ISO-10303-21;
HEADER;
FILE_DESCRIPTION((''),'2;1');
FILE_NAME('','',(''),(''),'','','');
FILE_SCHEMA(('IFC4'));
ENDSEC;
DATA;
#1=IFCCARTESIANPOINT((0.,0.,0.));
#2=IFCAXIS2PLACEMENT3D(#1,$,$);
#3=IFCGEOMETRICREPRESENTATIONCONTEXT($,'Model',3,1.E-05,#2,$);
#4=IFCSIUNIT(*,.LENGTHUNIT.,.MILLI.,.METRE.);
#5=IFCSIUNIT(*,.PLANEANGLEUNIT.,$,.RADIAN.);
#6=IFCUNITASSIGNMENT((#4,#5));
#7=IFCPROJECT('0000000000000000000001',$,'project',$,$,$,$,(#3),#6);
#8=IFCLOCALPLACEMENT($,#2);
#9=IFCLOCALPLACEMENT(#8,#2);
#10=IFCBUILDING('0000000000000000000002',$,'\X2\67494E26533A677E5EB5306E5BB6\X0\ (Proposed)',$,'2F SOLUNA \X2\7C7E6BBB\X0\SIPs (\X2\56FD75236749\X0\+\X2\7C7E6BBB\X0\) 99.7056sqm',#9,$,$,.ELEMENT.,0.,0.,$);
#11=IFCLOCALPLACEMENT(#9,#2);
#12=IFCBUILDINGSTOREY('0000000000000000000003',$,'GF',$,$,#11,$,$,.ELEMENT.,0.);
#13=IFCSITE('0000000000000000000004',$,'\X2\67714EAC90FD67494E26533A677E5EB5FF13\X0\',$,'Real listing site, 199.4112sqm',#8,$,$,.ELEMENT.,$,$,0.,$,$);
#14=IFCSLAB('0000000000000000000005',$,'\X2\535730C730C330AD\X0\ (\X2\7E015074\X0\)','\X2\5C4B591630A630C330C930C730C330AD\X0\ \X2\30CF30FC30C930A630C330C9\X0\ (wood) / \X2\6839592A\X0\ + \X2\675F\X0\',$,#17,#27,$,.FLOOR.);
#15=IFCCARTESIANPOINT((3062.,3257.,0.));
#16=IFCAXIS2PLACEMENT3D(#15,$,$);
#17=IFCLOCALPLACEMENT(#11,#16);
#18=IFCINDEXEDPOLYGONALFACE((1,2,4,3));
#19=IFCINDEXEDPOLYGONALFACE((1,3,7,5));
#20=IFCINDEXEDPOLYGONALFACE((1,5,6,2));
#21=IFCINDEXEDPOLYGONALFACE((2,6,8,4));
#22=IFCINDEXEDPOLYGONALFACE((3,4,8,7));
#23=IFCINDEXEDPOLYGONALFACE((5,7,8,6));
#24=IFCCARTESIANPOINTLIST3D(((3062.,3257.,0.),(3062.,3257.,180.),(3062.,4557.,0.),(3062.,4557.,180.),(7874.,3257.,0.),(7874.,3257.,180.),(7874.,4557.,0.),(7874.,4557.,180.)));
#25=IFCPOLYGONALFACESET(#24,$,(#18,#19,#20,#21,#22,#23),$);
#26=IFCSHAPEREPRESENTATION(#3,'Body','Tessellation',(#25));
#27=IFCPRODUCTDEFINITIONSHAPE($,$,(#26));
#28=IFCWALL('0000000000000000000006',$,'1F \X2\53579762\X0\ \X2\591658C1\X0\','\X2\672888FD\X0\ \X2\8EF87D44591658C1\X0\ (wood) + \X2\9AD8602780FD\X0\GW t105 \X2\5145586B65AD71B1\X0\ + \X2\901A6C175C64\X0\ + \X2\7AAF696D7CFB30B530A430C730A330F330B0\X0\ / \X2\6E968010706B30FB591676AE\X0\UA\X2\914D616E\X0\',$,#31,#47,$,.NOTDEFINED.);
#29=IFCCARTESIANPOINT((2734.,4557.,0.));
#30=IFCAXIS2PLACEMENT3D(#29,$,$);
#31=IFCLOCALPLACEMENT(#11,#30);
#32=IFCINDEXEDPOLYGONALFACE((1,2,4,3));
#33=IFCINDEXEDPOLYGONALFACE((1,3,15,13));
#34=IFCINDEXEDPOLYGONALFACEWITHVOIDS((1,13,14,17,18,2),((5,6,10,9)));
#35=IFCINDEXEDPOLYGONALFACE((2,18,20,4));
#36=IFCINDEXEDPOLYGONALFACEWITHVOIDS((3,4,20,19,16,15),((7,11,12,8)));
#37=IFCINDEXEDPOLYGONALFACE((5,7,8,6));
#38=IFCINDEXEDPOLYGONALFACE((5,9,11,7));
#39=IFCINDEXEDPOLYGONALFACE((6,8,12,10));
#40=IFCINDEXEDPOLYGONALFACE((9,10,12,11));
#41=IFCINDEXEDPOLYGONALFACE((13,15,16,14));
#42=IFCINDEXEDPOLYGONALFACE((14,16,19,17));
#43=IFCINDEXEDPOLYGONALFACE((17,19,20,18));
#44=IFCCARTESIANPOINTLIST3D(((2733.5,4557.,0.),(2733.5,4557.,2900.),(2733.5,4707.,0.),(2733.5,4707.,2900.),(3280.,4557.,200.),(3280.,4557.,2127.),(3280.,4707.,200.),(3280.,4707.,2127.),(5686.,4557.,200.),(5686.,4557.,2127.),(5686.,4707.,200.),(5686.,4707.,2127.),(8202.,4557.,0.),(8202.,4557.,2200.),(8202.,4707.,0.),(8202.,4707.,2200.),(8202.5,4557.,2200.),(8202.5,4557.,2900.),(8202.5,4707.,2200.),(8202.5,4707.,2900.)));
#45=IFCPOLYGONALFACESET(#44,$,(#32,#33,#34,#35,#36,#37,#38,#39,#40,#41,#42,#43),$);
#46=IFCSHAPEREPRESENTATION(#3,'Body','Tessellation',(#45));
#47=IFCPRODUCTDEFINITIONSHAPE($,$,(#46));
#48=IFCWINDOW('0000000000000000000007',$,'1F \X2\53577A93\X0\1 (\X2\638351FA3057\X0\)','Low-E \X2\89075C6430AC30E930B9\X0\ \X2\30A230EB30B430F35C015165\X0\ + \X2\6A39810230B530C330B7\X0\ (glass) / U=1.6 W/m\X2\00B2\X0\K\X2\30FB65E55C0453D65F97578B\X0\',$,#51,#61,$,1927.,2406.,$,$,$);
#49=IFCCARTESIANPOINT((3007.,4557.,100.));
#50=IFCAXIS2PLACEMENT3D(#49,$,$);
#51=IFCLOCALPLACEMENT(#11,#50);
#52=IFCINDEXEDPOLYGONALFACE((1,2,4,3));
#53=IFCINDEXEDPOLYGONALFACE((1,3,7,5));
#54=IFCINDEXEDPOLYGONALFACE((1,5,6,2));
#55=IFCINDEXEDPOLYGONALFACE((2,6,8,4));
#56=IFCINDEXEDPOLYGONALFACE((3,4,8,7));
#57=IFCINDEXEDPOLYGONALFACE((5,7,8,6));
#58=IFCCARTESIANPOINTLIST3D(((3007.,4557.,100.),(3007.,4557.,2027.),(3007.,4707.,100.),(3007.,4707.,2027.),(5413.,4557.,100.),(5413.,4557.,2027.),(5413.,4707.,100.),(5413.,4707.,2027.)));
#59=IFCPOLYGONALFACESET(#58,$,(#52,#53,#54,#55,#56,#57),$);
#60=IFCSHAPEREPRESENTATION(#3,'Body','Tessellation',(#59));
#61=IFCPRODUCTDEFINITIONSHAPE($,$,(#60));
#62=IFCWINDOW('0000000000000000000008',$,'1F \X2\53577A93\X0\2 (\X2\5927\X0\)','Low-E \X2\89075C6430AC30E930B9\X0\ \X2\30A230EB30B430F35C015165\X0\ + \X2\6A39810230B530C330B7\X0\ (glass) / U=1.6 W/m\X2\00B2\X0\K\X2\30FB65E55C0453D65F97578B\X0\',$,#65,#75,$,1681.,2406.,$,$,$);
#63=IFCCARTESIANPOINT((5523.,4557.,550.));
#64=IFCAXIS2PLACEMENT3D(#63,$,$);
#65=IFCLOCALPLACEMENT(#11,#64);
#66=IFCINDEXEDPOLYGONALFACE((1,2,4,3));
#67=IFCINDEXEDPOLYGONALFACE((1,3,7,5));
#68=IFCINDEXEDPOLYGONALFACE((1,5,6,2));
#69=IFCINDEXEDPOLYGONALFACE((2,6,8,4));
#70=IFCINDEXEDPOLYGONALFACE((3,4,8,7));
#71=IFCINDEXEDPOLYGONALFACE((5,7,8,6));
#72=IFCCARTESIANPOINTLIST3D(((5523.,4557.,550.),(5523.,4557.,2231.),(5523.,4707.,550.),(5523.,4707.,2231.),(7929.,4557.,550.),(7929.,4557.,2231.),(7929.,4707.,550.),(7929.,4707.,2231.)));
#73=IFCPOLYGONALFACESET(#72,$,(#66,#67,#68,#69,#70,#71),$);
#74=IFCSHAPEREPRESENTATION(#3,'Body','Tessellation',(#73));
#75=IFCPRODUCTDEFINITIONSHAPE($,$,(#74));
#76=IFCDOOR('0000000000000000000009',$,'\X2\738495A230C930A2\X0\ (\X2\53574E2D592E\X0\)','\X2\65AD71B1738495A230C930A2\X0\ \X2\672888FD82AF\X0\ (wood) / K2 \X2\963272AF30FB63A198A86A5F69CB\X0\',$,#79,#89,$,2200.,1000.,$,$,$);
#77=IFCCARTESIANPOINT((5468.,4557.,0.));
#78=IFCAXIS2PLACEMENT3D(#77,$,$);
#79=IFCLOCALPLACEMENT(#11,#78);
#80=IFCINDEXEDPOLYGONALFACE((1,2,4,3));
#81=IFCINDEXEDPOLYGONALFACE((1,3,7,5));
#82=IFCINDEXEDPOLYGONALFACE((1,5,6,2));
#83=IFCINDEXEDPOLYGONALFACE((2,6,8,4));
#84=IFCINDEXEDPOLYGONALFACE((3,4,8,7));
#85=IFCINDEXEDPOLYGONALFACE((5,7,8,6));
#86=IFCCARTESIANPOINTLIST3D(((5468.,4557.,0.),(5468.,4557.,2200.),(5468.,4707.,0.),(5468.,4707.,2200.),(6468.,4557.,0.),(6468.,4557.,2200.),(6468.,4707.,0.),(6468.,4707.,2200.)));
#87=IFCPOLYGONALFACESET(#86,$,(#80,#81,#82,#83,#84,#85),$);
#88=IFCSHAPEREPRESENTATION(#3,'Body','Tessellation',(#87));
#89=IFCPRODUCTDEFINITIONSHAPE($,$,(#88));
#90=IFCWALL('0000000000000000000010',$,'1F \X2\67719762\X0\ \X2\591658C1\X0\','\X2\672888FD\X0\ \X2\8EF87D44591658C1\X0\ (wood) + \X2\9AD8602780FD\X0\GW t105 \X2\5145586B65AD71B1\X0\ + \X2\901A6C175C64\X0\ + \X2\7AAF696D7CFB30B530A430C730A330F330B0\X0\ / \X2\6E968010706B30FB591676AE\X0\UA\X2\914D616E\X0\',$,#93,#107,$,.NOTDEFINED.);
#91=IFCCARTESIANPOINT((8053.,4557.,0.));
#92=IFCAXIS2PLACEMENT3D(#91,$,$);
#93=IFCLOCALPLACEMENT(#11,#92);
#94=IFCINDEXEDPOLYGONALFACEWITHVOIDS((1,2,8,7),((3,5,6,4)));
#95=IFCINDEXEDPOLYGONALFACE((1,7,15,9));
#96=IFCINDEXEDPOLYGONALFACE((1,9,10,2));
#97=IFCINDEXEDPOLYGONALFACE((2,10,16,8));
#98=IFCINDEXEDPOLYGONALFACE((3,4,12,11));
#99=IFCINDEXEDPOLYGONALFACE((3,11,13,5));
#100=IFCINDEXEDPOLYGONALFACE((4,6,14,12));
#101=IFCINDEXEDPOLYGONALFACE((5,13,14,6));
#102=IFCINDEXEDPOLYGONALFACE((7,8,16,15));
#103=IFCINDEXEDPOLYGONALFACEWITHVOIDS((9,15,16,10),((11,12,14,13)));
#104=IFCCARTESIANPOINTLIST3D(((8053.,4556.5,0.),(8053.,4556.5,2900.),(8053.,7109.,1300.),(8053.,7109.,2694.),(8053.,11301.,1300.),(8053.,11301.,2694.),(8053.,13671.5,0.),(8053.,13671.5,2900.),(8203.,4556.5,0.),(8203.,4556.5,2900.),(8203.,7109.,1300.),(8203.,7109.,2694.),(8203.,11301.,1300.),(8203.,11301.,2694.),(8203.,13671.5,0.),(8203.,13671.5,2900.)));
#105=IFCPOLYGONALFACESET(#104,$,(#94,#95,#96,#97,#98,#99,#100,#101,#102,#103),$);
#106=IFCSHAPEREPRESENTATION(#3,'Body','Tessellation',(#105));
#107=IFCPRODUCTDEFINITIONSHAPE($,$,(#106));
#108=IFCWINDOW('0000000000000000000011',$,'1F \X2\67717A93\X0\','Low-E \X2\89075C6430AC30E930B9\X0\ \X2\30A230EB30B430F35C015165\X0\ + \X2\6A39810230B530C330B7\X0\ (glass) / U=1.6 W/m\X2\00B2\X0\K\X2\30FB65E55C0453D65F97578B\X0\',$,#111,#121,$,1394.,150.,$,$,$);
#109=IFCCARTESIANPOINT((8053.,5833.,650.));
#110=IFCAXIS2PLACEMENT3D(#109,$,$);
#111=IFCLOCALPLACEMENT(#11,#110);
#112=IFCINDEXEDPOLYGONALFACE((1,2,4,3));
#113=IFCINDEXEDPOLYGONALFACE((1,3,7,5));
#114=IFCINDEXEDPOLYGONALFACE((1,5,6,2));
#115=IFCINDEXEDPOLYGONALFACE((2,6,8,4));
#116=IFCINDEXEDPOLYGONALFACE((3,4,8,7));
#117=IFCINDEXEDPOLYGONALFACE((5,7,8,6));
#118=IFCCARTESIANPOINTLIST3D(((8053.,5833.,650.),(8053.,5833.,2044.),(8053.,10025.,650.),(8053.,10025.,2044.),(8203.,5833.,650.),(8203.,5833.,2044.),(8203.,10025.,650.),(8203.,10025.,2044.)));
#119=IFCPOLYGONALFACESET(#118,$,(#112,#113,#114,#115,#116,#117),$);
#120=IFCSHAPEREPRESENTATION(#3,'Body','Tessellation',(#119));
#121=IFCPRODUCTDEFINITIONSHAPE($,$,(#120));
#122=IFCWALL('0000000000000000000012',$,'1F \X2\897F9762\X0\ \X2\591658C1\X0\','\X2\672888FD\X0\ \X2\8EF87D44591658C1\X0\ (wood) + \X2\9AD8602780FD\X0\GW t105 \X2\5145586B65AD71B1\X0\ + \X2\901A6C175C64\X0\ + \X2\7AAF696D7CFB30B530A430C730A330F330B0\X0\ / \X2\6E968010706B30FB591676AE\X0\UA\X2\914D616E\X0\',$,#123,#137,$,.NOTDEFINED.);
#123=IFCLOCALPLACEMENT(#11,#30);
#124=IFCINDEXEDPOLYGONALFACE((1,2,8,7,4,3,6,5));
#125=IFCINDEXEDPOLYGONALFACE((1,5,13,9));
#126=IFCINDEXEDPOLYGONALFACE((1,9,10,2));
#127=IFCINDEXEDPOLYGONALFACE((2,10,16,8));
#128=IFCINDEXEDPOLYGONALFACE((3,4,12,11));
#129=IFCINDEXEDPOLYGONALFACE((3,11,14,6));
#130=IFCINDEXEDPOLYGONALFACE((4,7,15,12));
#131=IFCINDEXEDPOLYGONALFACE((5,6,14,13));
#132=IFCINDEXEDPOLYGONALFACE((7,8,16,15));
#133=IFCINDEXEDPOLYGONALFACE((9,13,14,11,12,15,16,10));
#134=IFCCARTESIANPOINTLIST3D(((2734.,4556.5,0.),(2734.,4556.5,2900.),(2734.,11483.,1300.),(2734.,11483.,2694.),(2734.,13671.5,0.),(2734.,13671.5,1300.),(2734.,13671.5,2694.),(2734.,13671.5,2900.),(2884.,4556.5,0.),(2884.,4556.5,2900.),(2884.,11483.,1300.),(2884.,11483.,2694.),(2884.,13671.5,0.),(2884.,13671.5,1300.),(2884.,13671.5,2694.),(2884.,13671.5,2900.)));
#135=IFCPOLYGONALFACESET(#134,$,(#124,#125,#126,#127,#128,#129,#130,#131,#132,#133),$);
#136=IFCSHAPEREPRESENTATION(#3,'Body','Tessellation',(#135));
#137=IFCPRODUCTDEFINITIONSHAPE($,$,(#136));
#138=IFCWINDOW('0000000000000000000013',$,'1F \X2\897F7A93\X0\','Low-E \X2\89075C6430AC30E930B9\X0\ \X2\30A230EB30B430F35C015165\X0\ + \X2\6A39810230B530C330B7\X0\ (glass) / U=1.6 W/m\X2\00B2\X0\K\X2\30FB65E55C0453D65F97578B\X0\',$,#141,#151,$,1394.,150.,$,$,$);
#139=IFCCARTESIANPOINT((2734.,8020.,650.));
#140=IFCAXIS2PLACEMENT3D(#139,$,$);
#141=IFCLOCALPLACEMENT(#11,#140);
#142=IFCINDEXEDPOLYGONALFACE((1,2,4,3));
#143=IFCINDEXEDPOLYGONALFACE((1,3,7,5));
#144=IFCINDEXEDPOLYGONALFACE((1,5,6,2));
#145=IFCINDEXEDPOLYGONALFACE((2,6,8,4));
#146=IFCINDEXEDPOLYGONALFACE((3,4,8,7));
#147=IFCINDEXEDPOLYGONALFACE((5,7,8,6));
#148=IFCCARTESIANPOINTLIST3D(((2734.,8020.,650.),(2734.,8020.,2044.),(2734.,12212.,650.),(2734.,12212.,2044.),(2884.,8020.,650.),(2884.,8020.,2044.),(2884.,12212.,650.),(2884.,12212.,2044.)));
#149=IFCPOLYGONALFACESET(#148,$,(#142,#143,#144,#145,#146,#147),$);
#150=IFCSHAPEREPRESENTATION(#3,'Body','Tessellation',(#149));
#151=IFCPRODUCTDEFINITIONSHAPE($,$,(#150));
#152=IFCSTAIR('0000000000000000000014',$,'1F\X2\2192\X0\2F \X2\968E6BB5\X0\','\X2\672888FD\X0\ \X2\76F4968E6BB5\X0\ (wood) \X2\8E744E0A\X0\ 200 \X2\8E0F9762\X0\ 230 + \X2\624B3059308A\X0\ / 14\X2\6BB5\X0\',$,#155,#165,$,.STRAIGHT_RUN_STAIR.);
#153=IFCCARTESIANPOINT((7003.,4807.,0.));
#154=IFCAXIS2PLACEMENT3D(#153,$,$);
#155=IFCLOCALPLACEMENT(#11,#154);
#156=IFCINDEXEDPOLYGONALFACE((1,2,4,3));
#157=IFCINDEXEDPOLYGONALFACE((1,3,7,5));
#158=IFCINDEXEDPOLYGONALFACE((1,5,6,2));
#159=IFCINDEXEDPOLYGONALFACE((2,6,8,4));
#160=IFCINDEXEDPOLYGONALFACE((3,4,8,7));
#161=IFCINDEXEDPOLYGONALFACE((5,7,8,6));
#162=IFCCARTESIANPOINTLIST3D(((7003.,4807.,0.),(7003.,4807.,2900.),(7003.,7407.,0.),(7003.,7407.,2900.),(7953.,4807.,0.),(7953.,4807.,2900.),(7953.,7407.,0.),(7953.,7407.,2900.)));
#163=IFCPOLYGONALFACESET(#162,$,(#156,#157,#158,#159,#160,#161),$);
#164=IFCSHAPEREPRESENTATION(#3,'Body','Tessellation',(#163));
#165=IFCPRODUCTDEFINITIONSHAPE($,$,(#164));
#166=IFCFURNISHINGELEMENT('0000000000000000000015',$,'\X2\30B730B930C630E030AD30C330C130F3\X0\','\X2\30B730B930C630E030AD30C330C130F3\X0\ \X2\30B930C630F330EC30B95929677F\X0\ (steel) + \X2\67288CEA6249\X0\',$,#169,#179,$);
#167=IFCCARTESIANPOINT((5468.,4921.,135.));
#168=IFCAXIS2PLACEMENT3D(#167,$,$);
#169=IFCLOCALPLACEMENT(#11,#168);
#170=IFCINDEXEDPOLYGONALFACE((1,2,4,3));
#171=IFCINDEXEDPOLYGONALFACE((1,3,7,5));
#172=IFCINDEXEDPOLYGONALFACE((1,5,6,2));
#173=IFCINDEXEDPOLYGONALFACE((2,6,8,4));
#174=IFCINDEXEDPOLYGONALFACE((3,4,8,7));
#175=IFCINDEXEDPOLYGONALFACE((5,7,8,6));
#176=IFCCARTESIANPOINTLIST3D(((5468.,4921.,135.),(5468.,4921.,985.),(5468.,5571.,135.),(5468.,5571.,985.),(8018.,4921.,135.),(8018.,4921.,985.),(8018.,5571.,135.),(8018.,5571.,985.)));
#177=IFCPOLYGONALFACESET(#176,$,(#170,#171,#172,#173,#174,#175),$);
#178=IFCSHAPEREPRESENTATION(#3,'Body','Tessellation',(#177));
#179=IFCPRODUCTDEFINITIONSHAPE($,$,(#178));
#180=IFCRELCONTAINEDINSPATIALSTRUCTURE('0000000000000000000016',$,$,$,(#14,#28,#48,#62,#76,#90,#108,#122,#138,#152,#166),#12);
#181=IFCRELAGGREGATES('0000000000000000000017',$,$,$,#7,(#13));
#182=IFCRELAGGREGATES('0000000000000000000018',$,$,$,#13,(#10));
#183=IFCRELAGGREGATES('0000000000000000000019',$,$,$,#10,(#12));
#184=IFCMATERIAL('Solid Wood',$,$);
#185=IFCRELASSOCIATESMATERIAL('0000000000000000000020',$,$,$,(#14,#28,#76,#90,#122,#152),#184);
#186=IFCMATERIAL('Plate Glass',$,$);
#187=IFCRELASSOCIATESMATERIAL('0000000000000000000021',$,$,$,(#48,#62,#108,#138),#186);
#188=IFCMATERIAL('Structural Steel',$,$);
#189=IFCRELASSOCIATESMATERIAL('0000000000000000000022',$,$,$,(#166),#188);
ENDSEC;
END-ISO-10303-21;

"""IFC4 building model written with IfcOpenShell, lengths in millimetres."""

from ifc_helpers import new_model, si_unit, frame, frame_2d, origin, place, context, project, spatial, rectangle, extrude, material, element, fill, save


model = new_model("IFC4")

# Units and contexts
model_context = context("Model", 3, precision=1e-05, world=origin())
ifc_project = project(units=[si_unit("LENGTHUNIT", "METRE", prefix="MILLI"), si_unit("PLANEANGLEUNIT", "RADIAN")], contexts=[model_context])

# Site, building, storey
site_placement = place(None, origin())
site = spatial("IfcSite", under=ifc_project, at=site_placement, Name="東京都杉並区松庵３", ObjectType="Real listing site, 199.4112sqm", CompositionType="ELEMENT", RefElevation=0.0)
building_placement = place(site_placement, origin())
building = spatial("IfcBuilding", under=site, at=building_placement, Name="杉並区松庵の家 (Proposed)", ObjectType="2F SOLUNA 籾殻SIPs (国産杉+籾殻) 99.7056sqm", CompositionType="ELEMENT", ElevationOfRefHeight=0.0, ElevationOfTerrain=0.0)
storey_placement = place(building_placement, origin())
storey = spatial("IfcBuildingStorey", under=building, at=storey_placement, Name="GF", CompositionType="ELEMENT", Elevation=0.0)

# Slab
ifc_material_1 = material(Name="Solid Wood")
slab_1_placement = place(storey_placement, frame((3062.0, 3257.0, 0.0)))
element("IfcSlab", 1, at=slab_1_placement, inside=storey, material=ifc_material_1, Name="南デッキ (縁側)", Description="屋外ウッドデッキ ハードウッド (wood) / 根太 + 束", PredefinedType="FLOOR", context=model_context, shape_type="SweptSolid", body=[
    extrude(rectangle(XDim=4812.0, YDim=1300.0, at=frame_2d((2406.0, 650.0))), frame((3062.0, 3257.0, 0.0)), (0.0, 0.0, 1.0), 180.0),
])

# Wall, openings, windows, door
wall_1_placement = place(storey_placement, frame((2734.0, 4557.0, 0.0)))
wall_1 = element("IfcWall", 2, at=wall_1_placement, inside=storey, material=ifc_material_1, Name="1F 南面 外壁", Description="木製 軸組外壁 (wood) + 高性能GW t105 充填断熱 + 通気層 + 窯業系サイディング / 準耐火・外皮UA配慮", PredefinedType="NOTDEFINED", context=model_context, shape_type="SweptSolid", body=[
    extrude(rectangle(XDim=5469.0, YDim=150.0, at=frame_2d((2734.0, 75.0))), frame((2734.0, 4557.0, 0.0)), (0.0, 0.0, 1.0), 2900.0),
])
opening_1_placement = place(storey_placement, frame((3007.0, 4557.0, 100.0)))
opening_1 = element("IfcOpeningElement", 3, at=opening_1_placement, cuts=wall_1, PredefinedType="NOTDEFINED", context=model_context, shape_type="SweptSolid", body=[
    extrude(rectangle(XDim=2406.0, YDim=150.0, at=frame_2d((1203.0, 75.0))), frame((3007.0, 4557.0, 100.0)), (0.0, 0.0, 1.0), 1927.0),
])
opening_2_placement = place(storey_placement, frame((5523.0, 4557.0, 550.0)))
opening_2 = element("IfcOpeningElement", 4, at=opening_2_placement, cuts=wall_1, PredefinedType="NOTDEFINED", context=model_context, shape_type="SweptSolid", body=[
    extrude(rectangle(XDim=2406.0, YDim=150.0, at=frame_2d((1203.0, 75.0))), frame((5523.0, 4557.0, 550.0)), (0.0, 0.0, 1.0), 1681.0),
])
opening_3_placement = place(storey_placement, frame((5468.0, 4557.0, 0.0)))
opening_3 = element("IfcOpeningElement", 5, at=opening_3_placement, cuts=wall_1, PredefinedType="NOTDEFINED", context=model_context, shape_type="SweptSolid", body=[
    extrude(rectangle(XDim=1000.0, YDim=150.0, at=frame_2d((500.0, 75.0))), frame((5468.0, 4557.0, 0.0)), (0.0, 0.0, 1.0), 2200.0),
])
ifc_material_2 = material(Name="Plate Glass")
window_1_placement = place(storey_placement, frame((3007.0, 4557.0, 100.0)))
window_1 = element("IfcWindow", 6, at=window_1_placement, inside=storey, material=ifc_material_2, Name="1F 南窓1 (掃出し)", Description="Low-E 複層ガラス アルゴン封入 + 樹脂サッシ (glass) / U=1.6 W/m²K・日射取得型", OverallHeight=1927.0, OverallWidth=2406.0, context=model_context, shape_type="SweptSolid", body=[
    extrude(rectangle(XDim=2406.0, YDim=150.0, at=frame_2d((1203.0, 75.0))), frame((3007.0, 4557.0, 100.0)), (0.0, 0.0, 1.0), 1927.0),
])
fill(opening_1, window_1)
window_2_placement = place(storey_placement, frame((5523.0, 4557.0, 550.0)))
window_2 = element("IfcWindow", 7, at=window_2_placement, inside=storey, material=ifc_material_2, Name="1F 南窓2 (大)", Description="Low-E 複層ガラス アルゴン封入 + 樹脂サッシ (glass) / U=1.6 W/m²K・日射取得型", OverallHeight=1681.0, OverallWidth=2406.0, context=model_context, shape_type="SweptSolid", body=[
    extrude(rectangle(XDim=2406.0, YDim=150.0, at=frame_2d((1203.0, 75.0))), frame((5523.0, 4557.0, 550.0)), (0.0, 0.0, 1.0), 1681.0),
])
fill(opening_2, window_2)
door_placement = place(storey_placement, frame((5468.0, 4557.0, 0.0)))
door = element("IfcDoor", 8, at=door_placement, inside=storey, material=ifc_material_1, Name="玄関ドア (南中央)", Description="断熱玄関ドア 木製芯 (wood) / K2 防犯・採風機構", OverallHeight=2200.0, OverallWidth=1000.0, context=model_context, shape_type="SweptSolid", body=[
    extrude(rectangle(XDim=1000.0, YDim=150.0, at=frame_2d((500.0, 75.0))), frame((5468.0, 4557.0, 0.0)), (0.0, 0.0, 1.0), 2200.0),
])
fill(opening_3, door)

# Walls, openings, windows
wall_2_placement = place(storey_placement, frame((8053.0, 4557.0, 0.0)))
wall_2 = element("IfcWall", 9, at=wall_2_placement, inside=storey, material=ifc_material_1, Name="1F 東面 外壁", Description="木製 軸組外壁 (wood) + 高性能GW t105 充填断熱 + 通気層 + 窯業系サイディング / 準耐火・外皮UA配慮", PredefinedType="NOTDEFINED", context=model_context, shape_type="SweptSolid", body=[
    extrude(rectangle(XDim=150.0, YDim=9115.0, at=frame_2d((75.0, 4557.0))), frame((8053.0, 4557.0, 0.0)), (0.0, 0.0, 1.0), 2900.0),
])
opening_4_placement = place(storey_placement, frame((8053.0, 5833.0, 650.0)))
opening_4 = element("IfcOpeningElement", 10, at=opening_4_placement, cuts=wall_2, PredefinedType="NOTDEFINED", context=model_context, shape_type="SweptSolid", body=[
    extrude(rectangle(XDim=150.0, YDim=4192.0, at=frame_2d((75.0, 2096.0))), frame((8053.0, 5833.0, 650.0)), (0.0, 0.0, 1.0), 1394.0),
])
window_3_placement = place(storey_placement, frame((8053.0, 5833.0, 650.0)))
window_3 = element("IfcWindow", 11, at=window_3_placement, inside=storey, material=ifc_material_2, Name="1F 東窓", Description="Low-E 複層ガラス アルゴン封入 + 樹脂サッシ (glass) / U=1.6 W/m²K・日射取得型", OverallHeight=1394.0, OverallWidth=150.0, context=model_context, shape_type="SweptSolid", body=[
    extrude(rectangle(XDim=150.0, YDim=4192.0, at=frame_2d((75.0, 2096.0))), frame((8053.0, 5833.0, 650.0)), (0.0, 0.0, 1.0), 1394.0),
])
fill(opening_4, window_3)
wall_3_placement = place(storey_placement, frame((2734.0, 4557.0, 0.0)))
wall_3 = element("IfcWall", 12, at=wall_3_placement, inside=storey, material=ifc_material_1, Name="1F 西面 外壁", Description="木製 軸組外壁 (wood) + 高性能GW t105 充填断熱 + 通気層 + 窯業系サイディング / 準耐火・外皮UA配慮", PredefinedType="NOTDEFINED", context=model_context, shape_type="SweptSolid", body=[
    extrude(rectangle(XDim=150.0, YDim=9115.0, at=frame_2d((75.0, 4557.0))), frame((2734.0, 4557.0, 0.0)), (0.0, 0.0, 1.0), 2900.0),
])
opening_5_placement = place(storey_placement, frame((2734.0, 8020.0, 650.0)))
opening_5 = element("IfcOpeningElement", 13, at=opening_5_placement, cuts=wall_3, PredefinedType="NOTDEFINED", context=model_context, shape_type="SweptSolid", body=[
    extrude(rectangle(XDim=150.0, YDim=4192.0, at=frame_2d((75.0, 2096.0))), frame((2734.0, 8020.0, 650.0)), (0.0, 0.0, 1.0), 1394.0),
])
window_4_placement = place(storey_placement, frame((2734.0, 8020.0, 650.0)))
window_4 = element("IfcWindow", 14, at=window_4_placement, inside=storey, material=ifc_material_2, Name="1F 西窓", Description="Low-E 複層ガラス アルゴン封入 + 樹脂サッシ (glass) / U=1.6 W/m²K・日射取得型", OverallHeight=1394.0, OverallWidth=150.0, context=model_context, shape_type="SweptSolid", body=[
    extrude(rectangle(XDim=150.0, YDim=4192.0, at=frame_2d((75.0, 2096.0))), frame((2734.0, 8020.0, 650.0)), (0.0, 0.0, 1.0), 1394.0),
])
fill(opening_5, window_4)

# Stair
stair_placement = place(storey_placement, frame((7003.0, 4807.0, 0.0)))
element("IfcStair", 15, at=stair_placement, inside=storey, material=ifc_material_1, Name="1F→2F 階段", Description="木製 直階段 (wood) 蹴上 200 踏面 230 + 手すり / 14段", PredefinedType="STRAIGHT_RUN_STAIR", context=model_context, shape_type="SweptSolid", body=[
    extrude(rectangle(XDim=950.0, YDim=2600.0, at=frame_2d((475.0, 1300.0))), frame((7003.0, 4807.0, 0.0)), (0.0, 0.0, 1.0), 2900.0),
])

# Furnishing element
ifc_material_3 = material(Name="Structural Steel")
furnishing_placement = place(storey_placement, frame((5468.0, 4921.0, 135.0)))
element("IfcFurnishingElement", 16, at=furnishing_placement, inside=storey, material=ifc_material_3, Name="システムキッチン", Description="システムキッチン ステンレス天板 (steel) + 木質扉", context=model_context, shape_type="SweptSolid", body=[
    extrude(rectangle(XDim=2550.0, YDim=650.0, at=frame_2d((1275.0, 325.0))), frame((5468.0, 4921.0, 135.0)), (0.0, 0.0, 1.0), 850.0),
])

save(model, "model.ifc")
